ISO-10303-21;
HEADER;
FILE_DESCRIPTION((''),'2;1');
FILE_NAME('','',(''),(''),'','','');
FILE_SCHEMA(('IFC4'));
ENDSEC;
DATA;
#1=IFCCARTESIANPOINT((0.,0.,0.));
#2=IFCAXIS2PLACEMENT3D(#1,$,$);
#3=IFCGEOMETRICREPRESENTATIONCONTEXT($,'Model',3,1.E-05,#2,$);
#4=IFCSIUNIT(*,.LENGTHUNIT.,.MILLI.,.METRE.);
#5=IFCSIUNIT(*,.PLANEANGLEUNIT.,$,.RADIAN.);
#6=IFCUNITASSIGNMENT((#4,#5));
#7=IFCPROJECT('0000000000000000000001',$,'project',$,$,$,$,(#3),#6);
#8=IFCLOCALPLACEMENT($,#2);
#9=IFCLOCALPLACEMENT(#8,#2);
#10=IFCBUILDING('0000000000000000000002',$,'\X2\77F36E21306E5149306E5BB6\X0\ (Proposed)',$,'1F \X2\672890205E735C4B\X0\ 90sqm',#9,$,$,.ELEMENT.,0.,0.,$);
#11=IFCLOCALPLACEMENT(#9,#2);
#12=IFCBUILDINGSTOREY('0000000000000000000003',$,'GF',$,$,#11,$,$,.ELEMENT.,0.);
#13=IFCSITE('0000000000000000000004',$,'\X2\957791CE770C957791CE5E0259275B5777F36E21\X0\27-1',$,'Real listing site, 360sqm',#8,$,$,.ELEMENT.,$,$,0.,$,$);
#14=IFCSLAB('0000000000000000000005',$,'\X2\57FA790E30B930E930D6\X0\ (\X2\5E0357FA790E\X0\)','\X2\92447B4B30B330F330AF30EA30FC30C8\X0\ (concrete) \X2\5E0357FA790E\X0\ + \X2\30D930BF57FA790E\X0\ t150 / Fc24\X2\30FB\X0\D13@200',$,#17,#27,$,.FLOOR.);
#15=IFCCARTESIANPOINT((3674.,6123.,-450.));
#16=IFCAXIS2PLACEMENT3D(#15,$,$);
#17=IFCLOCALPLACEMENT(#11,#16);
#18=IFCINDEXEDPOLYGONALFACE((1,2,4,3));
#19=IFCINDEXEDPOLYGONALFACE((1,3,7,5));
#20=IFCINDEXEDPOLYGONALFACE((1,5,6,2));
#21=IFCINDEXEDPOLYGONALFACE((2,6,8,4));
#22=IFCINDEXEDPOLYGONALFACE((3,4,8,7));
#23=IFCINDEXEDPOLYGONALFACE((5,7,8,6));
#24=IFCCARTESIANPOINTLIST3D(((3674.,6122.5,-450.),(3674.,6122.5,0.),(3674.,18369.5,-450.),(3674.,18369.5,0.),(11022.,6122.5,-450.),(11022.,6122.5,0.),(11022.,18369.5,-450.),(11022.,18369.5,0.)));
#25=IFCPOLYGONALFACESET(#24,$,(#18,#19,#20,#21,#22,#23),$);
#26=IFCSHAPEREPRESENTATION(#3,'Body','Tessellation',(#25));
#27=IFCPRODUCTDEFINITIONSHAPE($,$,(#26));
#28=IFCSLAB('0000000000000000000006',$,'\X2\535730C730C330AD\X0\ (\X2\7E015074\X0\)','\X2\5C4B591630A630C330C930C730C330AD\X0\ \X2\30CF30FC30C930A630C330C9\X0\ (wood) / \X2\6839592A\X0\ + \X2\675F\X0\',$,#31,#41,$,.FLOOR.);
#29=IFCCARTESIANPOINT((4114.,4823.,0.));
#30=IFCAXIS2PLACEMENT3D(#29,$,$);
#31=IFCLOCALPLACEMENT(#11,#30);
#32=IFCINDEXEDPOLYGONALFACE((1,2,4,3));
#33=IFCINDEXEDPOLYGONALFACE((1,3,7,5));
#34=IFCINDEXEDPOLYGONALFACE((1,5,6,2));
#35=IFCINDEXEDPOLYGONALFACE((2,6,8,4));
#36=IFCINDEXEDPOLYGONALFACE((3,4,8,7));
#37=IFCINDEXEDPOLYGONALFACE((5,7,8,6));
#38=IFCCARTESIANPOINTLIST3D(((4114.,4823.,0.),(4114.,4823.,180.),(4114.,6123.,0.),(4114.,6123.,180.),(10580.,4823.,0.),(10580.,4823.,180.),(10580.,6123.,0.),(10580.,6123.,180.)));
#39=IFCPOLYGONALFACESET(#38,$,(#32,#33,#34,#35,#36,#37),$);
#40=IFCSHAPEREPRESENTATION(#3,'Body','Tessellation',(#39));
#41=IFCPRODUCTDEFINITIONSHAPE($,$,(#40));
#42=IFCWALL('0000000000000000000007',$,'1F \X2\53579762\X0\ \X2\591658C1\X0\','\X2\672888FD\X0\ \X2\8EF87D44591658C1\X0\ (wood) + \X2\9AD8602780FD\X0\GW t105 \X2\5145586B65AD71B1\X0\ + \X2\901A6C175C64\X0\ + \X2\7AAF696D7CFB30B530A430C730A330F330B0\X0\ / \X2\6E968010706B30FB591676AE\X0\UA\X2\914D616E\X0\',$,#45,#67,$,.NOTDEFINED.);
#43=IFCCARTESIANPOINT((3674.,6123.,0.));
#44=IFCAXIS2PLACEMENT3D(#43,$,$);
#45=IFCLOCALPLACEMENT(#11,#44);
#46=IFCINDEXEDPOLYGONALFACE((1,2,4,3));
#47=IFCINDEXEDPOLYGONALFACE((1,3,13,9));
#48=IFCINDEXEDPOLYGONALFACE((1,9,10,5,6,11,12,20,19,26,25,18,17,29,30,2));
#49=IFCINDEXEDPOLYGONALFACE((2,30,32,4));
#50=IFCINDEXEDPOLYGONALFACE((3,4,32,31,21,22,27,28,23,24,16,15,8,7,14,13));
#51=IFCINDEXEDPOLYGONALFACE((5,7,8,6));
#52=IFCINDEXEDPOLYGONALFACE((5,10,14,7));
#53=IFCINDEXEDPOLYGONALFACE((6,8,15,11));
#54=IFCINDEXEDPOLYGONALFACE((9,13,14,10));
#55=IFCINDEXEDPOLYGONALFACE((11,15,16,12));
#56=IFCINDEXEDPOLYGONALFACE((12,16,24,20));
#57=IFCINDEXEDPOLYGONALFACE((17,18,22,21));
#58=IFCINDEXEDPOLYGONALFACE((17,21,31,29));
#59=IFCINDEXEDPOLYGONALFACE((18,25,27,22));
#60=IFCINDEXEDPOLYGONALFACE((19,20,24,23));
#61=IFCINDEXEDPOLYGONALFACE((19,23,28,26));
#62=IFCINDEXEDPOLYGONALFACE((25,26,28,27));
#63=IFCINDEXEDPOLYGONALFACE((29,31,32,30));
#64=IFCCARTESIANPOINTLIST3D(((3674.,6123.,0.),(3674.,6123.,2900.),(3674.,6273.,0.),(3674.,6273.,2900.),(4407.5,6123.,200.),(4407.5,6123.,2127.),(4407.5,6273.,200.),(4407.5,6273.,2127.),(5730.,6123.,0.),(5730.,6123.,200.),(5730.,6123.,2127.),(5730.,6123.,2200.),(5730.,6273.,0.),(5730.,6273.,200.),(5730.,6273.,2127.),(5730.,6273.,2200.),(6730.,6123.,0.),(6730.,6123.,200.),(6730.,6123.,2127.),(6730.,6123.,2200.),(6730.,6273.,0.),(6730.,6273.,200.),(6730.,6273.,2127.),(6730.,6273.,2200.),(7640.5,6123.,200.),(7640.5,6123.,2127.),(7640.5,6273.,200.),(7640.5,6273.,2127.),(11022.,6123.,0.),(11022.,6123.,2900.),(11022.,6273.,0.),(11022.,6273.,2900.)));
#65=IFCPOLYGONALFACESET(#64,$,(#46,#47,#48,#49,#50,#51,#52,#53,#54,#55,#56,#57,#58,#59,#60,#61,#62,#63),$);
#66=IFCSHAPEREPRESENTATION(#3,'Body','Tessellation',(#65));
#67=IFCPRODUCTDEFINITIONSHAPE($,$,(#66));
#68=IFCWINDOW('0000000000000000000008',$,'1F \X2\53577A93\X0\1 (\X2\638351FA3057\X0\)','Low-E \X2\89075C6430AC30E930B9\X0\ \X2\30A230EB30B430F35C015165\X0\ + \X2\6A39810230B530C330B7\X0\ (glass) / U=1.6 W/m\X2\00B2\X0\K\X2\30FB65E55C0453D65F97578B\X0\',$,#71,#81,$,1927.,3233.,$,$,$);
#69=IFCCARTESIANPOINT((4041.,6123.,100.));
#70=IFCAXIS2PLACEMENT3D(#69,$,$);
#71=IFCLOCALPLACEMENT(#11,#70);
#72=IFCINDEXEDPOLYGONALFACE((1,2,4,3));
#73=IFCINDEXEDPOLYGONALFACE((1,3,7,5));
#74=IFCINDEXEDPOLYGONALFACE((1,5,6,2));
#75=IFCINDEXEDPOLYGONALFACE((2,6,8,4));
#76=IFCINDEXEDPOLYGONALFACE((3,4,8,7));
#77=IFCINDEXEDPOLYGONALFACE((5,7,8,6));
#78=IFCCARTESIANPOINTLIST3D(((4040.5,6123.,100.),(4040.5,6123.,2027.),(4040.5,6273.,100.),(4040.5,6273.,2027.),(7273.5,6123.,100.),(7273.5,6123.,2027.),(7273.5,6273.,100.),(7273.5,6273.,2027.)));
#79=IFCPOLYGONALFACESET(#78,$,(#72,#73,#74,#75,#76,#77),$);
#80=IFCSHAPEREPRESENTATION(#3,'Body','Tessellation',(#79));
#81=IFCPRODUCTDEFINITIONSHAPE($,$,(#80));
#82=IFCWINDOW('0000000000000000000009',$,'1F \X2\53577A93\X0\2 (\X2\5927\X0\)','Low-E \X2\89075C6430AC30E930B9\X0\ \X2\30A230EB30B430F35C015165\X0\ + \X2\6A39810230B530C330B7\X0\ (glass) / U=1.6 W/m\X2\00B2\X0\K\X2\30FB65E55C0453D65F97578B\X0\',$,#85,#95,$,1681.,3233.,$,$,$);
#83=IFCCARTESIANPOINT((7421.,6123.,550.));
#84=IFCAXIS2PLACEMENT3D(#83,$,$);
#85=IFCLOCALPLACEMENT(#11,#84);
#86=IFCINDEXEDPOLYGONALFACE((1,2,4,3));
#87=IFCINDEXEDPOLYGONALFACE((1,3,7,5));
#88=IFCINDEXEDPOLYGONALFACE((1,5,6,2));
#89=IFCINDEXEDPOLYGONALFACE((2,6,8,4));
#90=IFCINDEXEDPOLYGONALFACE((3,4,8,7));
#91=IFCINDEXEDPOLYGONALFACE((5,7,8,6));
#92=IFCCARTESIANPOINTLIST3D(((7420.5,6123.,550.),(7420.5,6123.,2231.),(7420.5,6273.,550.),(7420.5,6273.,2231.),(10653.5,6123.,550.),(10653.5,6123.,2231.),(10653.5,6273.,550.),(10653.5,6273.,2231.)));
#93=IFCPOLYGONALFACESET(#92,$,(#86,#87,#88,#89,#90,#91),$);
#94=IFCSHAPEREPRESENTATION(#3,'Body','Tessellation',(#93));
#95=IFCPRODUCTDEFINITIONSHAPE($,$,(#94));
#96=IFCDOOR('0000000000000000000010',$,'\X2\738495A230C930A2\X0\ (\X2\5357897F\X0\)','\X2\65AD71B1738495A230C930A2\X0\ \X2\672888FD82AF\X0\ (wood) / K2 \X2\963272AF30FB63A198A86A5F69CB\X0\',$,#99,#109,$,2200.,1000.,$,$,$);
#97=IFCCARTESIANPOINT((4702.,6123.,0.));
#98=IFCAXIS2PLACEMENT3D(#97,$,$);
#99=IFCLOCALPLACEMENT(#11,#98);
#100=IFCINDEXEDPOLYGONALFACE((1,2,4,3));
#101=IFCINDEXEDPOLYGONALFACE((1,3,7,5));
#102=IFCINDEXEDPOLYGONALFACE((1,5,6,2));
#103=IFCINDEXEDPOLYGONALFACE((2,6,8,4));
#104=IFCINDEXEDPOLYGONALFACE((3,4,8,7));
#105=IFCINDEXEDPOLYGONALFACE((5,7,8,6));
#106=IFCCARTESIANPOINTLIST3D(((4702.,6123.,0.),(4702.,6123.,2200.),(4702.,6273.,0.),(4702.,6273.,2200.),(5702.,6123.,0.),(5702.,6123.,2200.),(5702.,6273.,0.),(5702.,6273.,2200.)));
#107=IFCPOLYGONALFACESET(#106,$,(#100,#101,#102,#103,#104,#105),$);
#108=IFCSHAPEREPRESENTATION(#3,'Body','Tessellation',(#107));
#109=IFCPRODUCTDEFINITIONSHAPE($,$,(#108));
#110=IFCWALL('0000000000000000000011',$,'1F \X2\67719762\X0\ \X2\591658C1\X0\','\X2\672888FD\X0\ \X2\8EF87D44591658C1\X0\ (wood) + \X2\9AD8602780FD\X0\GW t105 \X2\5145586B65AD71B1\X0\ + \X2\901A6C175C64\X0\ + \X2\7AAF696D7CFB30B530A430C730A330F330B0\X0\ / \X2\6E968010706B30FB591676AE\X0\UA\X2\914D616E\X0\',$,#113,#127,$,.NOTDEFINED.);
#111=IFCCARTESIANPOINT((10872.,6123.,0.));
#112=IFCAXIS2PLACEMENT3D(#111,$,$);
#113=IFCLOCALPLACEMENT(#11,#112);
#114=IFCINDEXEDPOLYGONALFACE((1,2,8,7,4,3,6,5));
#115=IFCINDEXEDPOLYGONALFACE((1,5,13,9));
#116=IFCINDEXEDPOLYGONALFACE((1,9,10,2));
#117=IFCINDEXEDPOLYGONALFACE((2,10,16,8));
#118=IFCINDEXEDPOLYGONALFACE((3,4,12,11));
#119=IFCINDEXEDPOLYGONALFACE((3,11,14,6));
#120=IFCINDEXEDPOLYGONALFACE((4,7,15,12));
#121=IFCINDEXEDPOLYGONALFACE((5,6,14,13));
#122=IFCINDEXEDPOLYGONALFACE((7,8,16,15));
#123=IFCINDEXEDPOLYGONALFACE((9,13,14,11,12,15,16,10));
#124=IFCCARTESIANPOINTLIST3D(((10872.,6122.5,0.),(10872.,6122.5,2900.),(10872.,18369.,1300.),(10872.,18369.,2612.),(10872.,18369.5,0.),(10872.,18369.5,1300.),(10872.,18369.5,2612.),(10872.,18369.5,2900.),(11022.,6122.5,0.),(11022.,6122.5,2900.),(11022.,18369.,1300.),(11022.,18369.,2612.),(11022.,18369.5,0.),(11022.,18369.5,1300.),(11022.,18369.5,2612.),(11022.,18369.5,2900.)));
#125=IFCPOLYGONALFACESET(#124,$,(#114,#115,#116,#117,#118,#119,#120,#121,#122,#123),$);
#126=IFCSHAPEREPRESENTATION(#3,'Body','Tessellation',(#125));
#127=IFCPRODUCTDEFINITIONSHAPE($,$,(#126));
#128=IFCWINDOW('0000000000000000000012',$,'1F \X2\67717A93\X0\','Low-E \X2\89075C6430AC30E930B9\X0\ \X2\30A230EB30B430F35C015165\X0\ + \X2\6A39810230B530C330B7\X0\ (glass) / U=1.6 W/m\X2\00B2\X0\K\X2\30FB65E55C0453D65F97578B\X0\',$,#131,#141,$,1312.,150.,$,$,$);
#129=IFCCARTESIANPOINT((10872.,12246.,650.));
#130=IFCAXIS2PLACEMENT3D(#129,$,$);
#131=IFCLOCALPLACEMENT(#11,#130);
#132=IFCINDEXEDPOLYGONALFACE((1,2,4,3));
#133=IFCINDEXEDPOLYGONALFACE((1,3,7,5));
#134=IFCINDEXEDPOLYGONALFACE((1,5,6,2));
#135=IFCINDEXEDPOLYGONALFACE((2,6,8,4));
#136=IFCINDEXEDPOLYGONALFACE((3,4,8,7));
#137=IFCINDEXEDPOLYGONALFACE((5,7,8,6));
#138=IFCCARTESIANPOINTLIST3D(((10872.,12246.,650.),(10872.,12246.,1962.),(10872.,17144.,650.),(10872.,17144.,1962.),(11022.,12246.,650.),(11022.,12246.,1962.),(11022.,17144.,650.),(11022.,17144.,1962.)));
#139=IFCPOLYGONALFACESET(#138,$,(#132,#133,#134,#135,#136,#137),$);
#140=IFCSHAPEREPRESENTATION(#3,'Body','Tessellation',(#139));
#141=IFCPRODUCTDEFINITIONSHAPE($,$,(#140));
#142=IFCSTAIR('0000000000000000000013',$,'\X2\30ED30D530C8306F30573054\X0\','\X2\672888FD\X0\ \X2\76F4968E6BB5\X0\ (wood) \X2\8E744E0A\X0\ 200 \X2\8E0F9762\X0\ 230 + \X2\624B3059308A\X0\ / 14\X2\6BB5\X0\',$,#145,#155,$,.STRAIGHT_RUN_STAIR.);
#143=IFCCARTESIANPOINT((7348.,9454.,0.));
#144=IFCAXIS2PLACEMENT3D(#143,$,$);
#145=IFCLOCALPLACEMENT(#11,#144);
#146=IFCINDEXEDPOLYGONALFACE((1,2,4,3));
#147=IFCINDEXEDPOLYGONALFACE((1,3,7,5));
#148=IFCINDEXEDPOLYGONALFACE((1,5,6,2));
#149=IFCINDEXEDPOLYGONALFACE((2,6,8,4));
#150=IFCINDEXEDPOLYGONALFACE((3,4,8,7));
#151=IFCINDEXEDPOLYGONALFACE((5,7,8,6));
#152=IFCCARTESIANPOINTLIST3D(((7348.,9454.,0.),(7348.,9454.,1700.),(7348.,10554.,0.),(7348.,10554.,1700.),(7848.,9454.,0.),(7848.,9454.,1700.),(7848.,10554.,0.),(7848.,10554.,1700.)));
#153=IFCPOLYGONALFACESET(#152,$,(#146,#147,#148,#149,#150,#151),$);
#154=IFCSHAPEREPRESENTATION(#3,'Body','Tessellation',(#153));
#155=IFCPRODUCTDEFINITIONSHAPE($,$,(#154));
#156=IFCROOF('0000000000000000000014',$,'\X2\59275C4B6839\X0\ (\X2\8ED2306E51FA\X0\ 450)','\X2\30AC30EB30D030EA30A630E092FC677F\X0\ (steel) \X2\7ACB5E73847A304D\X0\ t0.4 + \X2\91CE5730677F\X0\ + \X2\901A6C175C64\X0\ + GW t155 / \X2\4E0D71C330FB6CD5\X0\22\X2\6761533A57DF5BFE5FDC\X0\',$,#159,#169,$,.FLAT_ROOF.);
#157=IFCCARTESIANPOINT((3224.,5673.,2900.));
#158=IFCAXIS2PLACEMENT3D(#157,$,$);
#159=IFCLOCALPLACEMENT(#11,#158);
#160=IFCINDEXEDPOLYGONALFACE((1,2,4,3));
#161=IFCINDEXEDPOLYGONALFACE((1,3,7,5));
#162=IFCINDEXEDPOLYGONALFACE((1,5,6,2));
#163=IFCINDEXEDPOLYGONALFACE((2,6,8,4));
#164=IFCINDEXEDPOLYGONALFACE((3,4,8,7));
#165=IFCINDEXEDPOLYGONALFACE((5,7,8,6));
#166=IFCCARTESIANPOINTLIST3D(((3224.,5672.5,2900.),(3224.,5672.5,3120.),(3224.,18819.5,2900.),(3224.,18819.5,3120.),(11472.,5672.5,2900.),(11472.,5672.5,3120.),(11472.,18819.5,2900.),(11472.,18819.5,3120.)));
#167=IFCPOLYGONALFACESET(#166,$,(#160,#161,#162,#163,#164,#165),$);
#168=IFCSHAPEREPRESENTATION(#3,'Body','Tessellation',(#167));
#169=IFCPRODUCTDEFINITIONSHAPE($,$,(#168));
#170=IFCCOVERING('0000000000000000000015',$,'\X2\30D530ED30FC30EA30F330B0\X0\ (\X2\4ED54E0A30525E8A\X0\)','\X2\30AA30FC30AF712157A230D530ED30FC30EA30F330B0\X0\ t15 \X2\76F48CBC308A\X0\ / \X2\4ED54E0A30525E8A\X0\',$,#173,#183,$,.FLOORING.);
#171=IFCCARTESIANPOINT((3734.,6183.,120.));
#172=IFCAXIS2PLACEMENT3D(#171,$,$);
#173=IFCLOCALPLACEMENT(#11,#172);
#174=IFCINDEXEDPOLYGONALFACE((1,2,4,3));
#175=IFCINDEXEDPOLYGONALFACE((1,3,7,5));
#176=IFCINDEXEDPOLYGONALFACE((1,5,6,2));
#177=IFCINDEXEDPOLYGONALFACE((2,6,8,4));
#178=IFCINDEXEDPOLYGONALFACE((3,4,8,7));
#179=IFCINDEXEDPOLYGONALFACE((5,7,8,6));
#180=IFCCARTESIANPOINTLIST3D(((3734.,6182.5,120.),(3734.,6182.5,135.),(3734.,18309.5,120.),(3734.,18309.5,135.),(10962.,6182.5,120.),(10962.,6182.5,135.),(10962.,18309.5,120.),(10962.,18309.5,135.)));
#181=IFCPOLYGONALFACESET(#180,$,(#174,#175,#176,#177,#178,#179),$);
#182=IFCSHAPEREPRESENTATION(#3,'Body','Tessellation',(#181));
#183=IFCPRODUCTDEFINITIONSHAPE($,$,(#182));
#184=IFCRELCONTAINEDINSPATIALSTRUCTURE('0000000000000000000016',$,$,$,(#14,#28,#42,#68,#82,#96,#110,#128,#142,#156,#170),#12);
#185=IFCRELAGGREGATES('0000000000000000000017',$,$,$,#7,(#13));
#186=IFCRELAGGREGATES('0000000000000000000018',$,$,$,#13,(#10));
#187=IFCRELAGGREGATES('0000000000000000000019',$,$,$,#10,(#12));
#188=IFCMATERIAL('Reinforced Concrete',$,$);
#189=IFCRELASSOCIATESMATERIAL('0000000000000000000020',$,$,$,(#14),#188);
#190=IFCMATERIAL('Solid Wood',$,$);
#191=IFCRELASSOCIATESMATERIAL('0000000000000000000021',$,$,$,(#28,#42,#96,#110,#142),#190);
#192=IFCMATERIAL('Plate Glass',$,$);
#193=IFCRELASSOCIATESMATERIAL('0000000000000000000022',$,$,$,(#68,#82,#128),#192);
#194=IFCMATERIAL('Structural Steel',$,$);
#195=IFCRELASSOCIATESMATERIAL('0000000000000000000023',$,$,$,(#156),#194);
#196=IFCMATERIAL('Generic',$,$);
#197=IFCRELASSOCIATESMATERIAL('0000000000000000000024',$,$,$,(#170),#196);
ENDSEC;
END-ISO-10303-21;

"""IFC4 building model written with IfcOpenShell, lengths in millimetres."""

from ifc_helpers import new_model, si_unit, frame, frame_2d, origin, place, context, project, spatial, rectangle, extrude, material, element, fill, save


model = new_model("IFC4")

# Units and contexts
model_context = context("Model", 3, precision=1e-05, world=origin())
ifc_project = project(units=[si_unit("LENGTHUNIT", "METRE", prefix="MILLI"), si_unit("PLANEANGLEUNIT", "RADIAN")], contexts=[model_context])

# Site, building, storey
site_placement = place(None, origin())
site = spatial("IfcSite", under=ifc_project, at=site_placement, Name="長野県長野市大字石渡27-1", ObjectType="Real listing site, 360sqm", CompositionType="ELEMENT", RefElevation=0.0)
building_placement = place(site_placement, origin())
building = spatial("IfcBuilding", under=site, at=building_placement, Name="石渡の光の家 (Proposed)", ObjectType="1F 木造平屋 90sqm", CompositionType="ELEMENT", ElevationOfRefHeight=0.0, ElevationOfTerrain=0.0)
storey_placement = place(building_placement, origin())
storey = spatial("IfcBuildingStorey", under=building, at=storey_placement, Name="GF", CompositionType="ELEMENT", Elevation=0.0)

# Slabs
ifc_material_1 = material(Name="Reinforced Concrete")
slab_1_placement = place(storey_placement, frame((3674.0, 6123.0, -450.0)))
element("IfcSlab", 1, at=slab_1_placement, inside=storey, material=ifc_material_1, Name="基礎スラブ (布基礎)", Description="鉄筋コンクリート (concrete) 布基礎 + ベタ基礎 t150 / Fc24・D13@200", PredefinedType="FLOOR", context=model_context, shape_type="SweptSolid", body=[
    extrude(rectangle(XDim=7348.0, YDim=12247.0, at=frame_2d((3674.0, 6123.0))), frame((3674.0, 6123.0, -450.0)), (0.0, 0.0, 1.0), 450.0),
])
ifc_material_2 = material(Name="Solid Wood")
slab_2_placement = place(storey_placement, frame((4114.0, 4823.0, 0.0)))
element("IfcSlab", 2, at=slab_2_placement, inside=storey, material=ifc_material_2, Name="南デッキ (縁側)", Description="屋外ウッドデッキ ハードウッド (wood) / 根太 + 束", PredefinedType="FLOOR", context=model_context, shape_type="SweptSolid", body=[
    extrude(rectangle(XDim=6466.0, YDim=1300.0, at=frame_2d((3233.0, 650.0))), frame((4114.0, 4823.0, 0.0)), (0.0, 0.0, 1.0), 180.0),
])

# Wall, openings, windows, door
wall_1_placement = place(storey_placement, frame((3674.0, 6123.0, 0.0)))
wall_1 = element("IfcWall", 3, at=wall_1_placement, inside=storey, material=ifc_material_2, Name="1F 南面 外壁", Description="木製 軸組外壁 (wood) + 高性能GW t105 充填断熱 + 通気層 + 窯業系サイディング / 準耐火・外皮UA配慮", PredefinedType="NOTDEFINED", context=model_context, shape_type="SweptSolid", body=[
    extrude(rectangle(XDim=7348.0, YDim=150.0, at=frame_2d((3674.0, 75.0))), frame((3674.0, 6123.0, 0.0)), (0.0, 0.0, 1.0), 2900.0),
])
opening_1_placement = place(storey_placement, frame((4041.0, 6123.0, 100.0)))
opening_1 = element("IfcOpeningElement", 4, at=opening_1_placement, cuts=wall_1, PredefinedType="NOTDEFINED", context=model_context, shape_type="SweptSolid", body=[
    extrude(rectangle(XDim=3233.0, YDim=150.0, at=frame_2d((1616.0, 75.0))), frame((4041.0, 6123.0, 100.0)), (0.0, 0.0, 1.0), 1927.0),
])
opening_2_placement = place(storey_placement, frame((7421.0, 6123.0, 550.0)))
opening_2 = element("IfcOpeningElement", 5, at=opening_2_placement, cuts=wall_1, PredefinedType="NOTDEFINED", context=model_context, shape_type="SweptSolid", body=[
    extrude(rectangle(XDim=3233.0, YDim=150.0, at=frame_2d((1616.0, 75.0))), frame((7421.0, 6123.0, 550.0)), (0.0, 0.0, 1.0), 1681.0),
])
opening_3_placement = place(storey_placement, frame((4702.0, 6123.0, 0.0)))
opening_3 = element("IfcOpeningElement", 6, at=opening_3_placement, cuts=wall_1, PredefinedType="NOTDEFINED", context=model_context, shape_type="SweptSolid", body=[
    extrude(rectangle(XDim=1000.0, YDim=150.0, at=frame_2d((500.0, 75.0))), frame((4702.0, 6123.0, 0.0)), (0.0, 0.0, 1.0), 2200.0),
])
ifc_material_3 = material(Name="Plate Glass")
window_1_placement = place(storey_placement, frame((4041.0, 6123.0, 100.0)))
window_1 = element("IfcWindow", 7, at=window_1_placement, inside=storey, material=ifc_material_3, Name="1F 南窓1 (掃出し)", Description="Low-E 複層ガラス アルゴン封入 + 樹脂サッシ (glass) / U=1.6 W/m²K・日射取得型", OverallHeight=1927.0, OverallWidth=3233.0, context=model_context, shape_type="SweptSolid", body=[
    extrude(rectangle(XDim=3233.0, YDim=150.0, at=frame_2d((1616.0, 75.0))), frame((4041.0, 6123.0, 100.0)), (0.0, 0.0, 1.0), 1927.0),
])
fill(opening_1, window_1)
window_2_placement = place(storey_placement, frame((7421.0, 6123.0, 550.0)))
window_2 = element("IfcWindow", 8, at=window_2_placement, inside=storey, material=ifc_material_3, Name="1F 南窓2 (大)", Description="Low-E 複層ガラス アルゴン封入 + 樹脂サッシ (glass) / U=1.6 W/m²K・日射取得型", OverallHeight=1681.0, OverallWidth=3233.0, context=model_context, shape_type="SweptSolid", body=[
    extrude(rectangle(XDim=3233.0, YDim=150.0, at=frame_2d((1616.0, 75.0))), frame((7421.0, 6123.0, 550.0)), (0.0, 0.0, 1.0), 1681.0),
])
fill(opening_2, window_2)
door_placement = place(storey_placement, frame((4702.0, 6123.0, 0.0)))
door = element("IfcDoor", 9, at=door_placement, inside=storey, material=ifc_material_2, Name="玄関ドア (南西)", Description="断熱玄関ドア 木製芯 (wood) / K2 防犯・採風機構", OverallHeight=2200.0, OverallWidth=1000.0, context=model_context, shape_type="SweptSolid", body=[
    extrude(rectangle(XDim=1000.0, YDim=150.0, at=frame_2d((500.0, 75.0))), frame((4702.0, 6123.0, 0.0)), (0.0, 0.0, 1.0), 2200.0),
])
fill(opening_3, door)

# Wall, opening, window
wall_2_placement = place(storey_placement, frame((10872.0, 6123.0, 0.0)))
wall_2 = element("IfcWall", 10, at=wall_2_placement, inside=storey, material=ifc_material_2, Name="1F 東面 外壁", Description="木製 軸組外壁 (wood) + 高性能GW t105 充填断熱 + 通気層 + 窯業系サイディング / 準耐火・外皮UA配慮", PredefinedType="NOTDEFINED", context=model_context, shape_type="SweptSolid", body=[
    extrude(rectangle(XDim=150.0, YDim=12247.0, at=frame_2d((75.0, 6123.0))), frame((10872.0, 6123.0, 0.0)), (0.0, 0.0, 1.0), 2900.0),
])
opening_4_placement = place(storey_placement, frame((10872.0, 12246.0, 650.0)))
opening_4 = element("IfcOpeningElement", 11, at=opening_4_placement, cuts=wall_2, PredefinedType="NOTDEFINED", context=model_context, shape_type="SweptSolid", body=[
    extrude(rectangle(XDim=150.0, YDim=4898.0, at=frame_2d((75.0, 2449.0))), frame((10872.0, 12246.0, 650.0)), (0.0, 0.0, 1.0), 1312.0),
])
window_3_placement = place(storey_placement, frame((10872.0, 12246.0, 650.0)))
window_3 = element("IfcWindow", 12, at=window_3_placement, inside=storey, material=ifc_material_3, Name="1F 東窓", Description="Low-E 複層ガラス アルゴン封入 + 樹脂サッシ (glass) / U=1.6 W/m²K・日射取得型", OverallHeight=1312.0, OverallWidth=150.0, context=model_context, shape_type="SweptSolid", body=[
    extrude(rectangle(XDim=150.0, YDim=4898.0, at=frame_2d((75.0, 2449.0))), frame((10872.0, 12246.0, 650.0)), (0.0, 0.0, 1.0), 1312.0),
])
fill(opening_4, window_3)

# Stair
stair_placement = place(storey_placement, frame((7348.0, 9454.0, 0.0)))
element("IfcStair", 13, at=stair_placement, inside=storey, material=ifc_material_2, Name="ロフトはしご", Description="木製 直階段 (wood) 蹴上 200 踏面 230 + 手すり / 14段", PredefinedType="STRAIGHT_RUN_STAIR", context=model_context, shape_type="SweptSolid", body=[
    extrude(rectangle(XDim=500.0, YDim=1100.0, at=frame_2d((250.0, 550.0))), frame((7348.0, 9454.0, 0.0)), (0.0, 0.0, 1.0), 1700.0),
])

# Roof
ifc_material_4 = material(Name="Structural Steel")
roof_placement = place(storey_placement, frame((3224.0, 5673.0, 2900.0)))
element("IfcRoof", 14, at=roof_placement, inside=storey, material=ifc_material_4, Name="大屋根 (軒の出 450)", Description="ガルバリウム鋼板 (steel) 立平葺き t0.4 + 野地板 + 通気層 + GW t155 / 不燃・法22条区域対応", PredefinedType="FLAT_ROOF", context=model_context, shape_type="SweptSolid", body=[
    extrude(rectangle(XDim=8248.0, YDim=13147.0, at=frame_2d((4124.0, 6573.0))), frame((3224.0, 5673.0, 2900.0)), (0.0, 0.0, 1.0), 220.0),
])

# Covering
ifc_material_5 = material(Name="Generic")
covering_placement = place(storey_placement, frame((3734.0, 6183.0, 120.0)))
element("IfcCovering", 15, at=covering_placement, inside=storey, material=ifc_material_5, Name="フローリング (仕上げ床)", Description="オーク無垢フローリング t15 直貼り / 仕上げ床", PredefinedType="FLOORING", context=model_context, shape_type="SweptSolid", body=[
    extrude(rectangle(XDim=7228.0, YDim=12127.0, at=frame_2d((3614.0, 6063.0))), frame((3734.0, 6183.0, 120.0)), (0.0, 0.0, 1.0), 15.0),
])

save(model, "model.ifc")
